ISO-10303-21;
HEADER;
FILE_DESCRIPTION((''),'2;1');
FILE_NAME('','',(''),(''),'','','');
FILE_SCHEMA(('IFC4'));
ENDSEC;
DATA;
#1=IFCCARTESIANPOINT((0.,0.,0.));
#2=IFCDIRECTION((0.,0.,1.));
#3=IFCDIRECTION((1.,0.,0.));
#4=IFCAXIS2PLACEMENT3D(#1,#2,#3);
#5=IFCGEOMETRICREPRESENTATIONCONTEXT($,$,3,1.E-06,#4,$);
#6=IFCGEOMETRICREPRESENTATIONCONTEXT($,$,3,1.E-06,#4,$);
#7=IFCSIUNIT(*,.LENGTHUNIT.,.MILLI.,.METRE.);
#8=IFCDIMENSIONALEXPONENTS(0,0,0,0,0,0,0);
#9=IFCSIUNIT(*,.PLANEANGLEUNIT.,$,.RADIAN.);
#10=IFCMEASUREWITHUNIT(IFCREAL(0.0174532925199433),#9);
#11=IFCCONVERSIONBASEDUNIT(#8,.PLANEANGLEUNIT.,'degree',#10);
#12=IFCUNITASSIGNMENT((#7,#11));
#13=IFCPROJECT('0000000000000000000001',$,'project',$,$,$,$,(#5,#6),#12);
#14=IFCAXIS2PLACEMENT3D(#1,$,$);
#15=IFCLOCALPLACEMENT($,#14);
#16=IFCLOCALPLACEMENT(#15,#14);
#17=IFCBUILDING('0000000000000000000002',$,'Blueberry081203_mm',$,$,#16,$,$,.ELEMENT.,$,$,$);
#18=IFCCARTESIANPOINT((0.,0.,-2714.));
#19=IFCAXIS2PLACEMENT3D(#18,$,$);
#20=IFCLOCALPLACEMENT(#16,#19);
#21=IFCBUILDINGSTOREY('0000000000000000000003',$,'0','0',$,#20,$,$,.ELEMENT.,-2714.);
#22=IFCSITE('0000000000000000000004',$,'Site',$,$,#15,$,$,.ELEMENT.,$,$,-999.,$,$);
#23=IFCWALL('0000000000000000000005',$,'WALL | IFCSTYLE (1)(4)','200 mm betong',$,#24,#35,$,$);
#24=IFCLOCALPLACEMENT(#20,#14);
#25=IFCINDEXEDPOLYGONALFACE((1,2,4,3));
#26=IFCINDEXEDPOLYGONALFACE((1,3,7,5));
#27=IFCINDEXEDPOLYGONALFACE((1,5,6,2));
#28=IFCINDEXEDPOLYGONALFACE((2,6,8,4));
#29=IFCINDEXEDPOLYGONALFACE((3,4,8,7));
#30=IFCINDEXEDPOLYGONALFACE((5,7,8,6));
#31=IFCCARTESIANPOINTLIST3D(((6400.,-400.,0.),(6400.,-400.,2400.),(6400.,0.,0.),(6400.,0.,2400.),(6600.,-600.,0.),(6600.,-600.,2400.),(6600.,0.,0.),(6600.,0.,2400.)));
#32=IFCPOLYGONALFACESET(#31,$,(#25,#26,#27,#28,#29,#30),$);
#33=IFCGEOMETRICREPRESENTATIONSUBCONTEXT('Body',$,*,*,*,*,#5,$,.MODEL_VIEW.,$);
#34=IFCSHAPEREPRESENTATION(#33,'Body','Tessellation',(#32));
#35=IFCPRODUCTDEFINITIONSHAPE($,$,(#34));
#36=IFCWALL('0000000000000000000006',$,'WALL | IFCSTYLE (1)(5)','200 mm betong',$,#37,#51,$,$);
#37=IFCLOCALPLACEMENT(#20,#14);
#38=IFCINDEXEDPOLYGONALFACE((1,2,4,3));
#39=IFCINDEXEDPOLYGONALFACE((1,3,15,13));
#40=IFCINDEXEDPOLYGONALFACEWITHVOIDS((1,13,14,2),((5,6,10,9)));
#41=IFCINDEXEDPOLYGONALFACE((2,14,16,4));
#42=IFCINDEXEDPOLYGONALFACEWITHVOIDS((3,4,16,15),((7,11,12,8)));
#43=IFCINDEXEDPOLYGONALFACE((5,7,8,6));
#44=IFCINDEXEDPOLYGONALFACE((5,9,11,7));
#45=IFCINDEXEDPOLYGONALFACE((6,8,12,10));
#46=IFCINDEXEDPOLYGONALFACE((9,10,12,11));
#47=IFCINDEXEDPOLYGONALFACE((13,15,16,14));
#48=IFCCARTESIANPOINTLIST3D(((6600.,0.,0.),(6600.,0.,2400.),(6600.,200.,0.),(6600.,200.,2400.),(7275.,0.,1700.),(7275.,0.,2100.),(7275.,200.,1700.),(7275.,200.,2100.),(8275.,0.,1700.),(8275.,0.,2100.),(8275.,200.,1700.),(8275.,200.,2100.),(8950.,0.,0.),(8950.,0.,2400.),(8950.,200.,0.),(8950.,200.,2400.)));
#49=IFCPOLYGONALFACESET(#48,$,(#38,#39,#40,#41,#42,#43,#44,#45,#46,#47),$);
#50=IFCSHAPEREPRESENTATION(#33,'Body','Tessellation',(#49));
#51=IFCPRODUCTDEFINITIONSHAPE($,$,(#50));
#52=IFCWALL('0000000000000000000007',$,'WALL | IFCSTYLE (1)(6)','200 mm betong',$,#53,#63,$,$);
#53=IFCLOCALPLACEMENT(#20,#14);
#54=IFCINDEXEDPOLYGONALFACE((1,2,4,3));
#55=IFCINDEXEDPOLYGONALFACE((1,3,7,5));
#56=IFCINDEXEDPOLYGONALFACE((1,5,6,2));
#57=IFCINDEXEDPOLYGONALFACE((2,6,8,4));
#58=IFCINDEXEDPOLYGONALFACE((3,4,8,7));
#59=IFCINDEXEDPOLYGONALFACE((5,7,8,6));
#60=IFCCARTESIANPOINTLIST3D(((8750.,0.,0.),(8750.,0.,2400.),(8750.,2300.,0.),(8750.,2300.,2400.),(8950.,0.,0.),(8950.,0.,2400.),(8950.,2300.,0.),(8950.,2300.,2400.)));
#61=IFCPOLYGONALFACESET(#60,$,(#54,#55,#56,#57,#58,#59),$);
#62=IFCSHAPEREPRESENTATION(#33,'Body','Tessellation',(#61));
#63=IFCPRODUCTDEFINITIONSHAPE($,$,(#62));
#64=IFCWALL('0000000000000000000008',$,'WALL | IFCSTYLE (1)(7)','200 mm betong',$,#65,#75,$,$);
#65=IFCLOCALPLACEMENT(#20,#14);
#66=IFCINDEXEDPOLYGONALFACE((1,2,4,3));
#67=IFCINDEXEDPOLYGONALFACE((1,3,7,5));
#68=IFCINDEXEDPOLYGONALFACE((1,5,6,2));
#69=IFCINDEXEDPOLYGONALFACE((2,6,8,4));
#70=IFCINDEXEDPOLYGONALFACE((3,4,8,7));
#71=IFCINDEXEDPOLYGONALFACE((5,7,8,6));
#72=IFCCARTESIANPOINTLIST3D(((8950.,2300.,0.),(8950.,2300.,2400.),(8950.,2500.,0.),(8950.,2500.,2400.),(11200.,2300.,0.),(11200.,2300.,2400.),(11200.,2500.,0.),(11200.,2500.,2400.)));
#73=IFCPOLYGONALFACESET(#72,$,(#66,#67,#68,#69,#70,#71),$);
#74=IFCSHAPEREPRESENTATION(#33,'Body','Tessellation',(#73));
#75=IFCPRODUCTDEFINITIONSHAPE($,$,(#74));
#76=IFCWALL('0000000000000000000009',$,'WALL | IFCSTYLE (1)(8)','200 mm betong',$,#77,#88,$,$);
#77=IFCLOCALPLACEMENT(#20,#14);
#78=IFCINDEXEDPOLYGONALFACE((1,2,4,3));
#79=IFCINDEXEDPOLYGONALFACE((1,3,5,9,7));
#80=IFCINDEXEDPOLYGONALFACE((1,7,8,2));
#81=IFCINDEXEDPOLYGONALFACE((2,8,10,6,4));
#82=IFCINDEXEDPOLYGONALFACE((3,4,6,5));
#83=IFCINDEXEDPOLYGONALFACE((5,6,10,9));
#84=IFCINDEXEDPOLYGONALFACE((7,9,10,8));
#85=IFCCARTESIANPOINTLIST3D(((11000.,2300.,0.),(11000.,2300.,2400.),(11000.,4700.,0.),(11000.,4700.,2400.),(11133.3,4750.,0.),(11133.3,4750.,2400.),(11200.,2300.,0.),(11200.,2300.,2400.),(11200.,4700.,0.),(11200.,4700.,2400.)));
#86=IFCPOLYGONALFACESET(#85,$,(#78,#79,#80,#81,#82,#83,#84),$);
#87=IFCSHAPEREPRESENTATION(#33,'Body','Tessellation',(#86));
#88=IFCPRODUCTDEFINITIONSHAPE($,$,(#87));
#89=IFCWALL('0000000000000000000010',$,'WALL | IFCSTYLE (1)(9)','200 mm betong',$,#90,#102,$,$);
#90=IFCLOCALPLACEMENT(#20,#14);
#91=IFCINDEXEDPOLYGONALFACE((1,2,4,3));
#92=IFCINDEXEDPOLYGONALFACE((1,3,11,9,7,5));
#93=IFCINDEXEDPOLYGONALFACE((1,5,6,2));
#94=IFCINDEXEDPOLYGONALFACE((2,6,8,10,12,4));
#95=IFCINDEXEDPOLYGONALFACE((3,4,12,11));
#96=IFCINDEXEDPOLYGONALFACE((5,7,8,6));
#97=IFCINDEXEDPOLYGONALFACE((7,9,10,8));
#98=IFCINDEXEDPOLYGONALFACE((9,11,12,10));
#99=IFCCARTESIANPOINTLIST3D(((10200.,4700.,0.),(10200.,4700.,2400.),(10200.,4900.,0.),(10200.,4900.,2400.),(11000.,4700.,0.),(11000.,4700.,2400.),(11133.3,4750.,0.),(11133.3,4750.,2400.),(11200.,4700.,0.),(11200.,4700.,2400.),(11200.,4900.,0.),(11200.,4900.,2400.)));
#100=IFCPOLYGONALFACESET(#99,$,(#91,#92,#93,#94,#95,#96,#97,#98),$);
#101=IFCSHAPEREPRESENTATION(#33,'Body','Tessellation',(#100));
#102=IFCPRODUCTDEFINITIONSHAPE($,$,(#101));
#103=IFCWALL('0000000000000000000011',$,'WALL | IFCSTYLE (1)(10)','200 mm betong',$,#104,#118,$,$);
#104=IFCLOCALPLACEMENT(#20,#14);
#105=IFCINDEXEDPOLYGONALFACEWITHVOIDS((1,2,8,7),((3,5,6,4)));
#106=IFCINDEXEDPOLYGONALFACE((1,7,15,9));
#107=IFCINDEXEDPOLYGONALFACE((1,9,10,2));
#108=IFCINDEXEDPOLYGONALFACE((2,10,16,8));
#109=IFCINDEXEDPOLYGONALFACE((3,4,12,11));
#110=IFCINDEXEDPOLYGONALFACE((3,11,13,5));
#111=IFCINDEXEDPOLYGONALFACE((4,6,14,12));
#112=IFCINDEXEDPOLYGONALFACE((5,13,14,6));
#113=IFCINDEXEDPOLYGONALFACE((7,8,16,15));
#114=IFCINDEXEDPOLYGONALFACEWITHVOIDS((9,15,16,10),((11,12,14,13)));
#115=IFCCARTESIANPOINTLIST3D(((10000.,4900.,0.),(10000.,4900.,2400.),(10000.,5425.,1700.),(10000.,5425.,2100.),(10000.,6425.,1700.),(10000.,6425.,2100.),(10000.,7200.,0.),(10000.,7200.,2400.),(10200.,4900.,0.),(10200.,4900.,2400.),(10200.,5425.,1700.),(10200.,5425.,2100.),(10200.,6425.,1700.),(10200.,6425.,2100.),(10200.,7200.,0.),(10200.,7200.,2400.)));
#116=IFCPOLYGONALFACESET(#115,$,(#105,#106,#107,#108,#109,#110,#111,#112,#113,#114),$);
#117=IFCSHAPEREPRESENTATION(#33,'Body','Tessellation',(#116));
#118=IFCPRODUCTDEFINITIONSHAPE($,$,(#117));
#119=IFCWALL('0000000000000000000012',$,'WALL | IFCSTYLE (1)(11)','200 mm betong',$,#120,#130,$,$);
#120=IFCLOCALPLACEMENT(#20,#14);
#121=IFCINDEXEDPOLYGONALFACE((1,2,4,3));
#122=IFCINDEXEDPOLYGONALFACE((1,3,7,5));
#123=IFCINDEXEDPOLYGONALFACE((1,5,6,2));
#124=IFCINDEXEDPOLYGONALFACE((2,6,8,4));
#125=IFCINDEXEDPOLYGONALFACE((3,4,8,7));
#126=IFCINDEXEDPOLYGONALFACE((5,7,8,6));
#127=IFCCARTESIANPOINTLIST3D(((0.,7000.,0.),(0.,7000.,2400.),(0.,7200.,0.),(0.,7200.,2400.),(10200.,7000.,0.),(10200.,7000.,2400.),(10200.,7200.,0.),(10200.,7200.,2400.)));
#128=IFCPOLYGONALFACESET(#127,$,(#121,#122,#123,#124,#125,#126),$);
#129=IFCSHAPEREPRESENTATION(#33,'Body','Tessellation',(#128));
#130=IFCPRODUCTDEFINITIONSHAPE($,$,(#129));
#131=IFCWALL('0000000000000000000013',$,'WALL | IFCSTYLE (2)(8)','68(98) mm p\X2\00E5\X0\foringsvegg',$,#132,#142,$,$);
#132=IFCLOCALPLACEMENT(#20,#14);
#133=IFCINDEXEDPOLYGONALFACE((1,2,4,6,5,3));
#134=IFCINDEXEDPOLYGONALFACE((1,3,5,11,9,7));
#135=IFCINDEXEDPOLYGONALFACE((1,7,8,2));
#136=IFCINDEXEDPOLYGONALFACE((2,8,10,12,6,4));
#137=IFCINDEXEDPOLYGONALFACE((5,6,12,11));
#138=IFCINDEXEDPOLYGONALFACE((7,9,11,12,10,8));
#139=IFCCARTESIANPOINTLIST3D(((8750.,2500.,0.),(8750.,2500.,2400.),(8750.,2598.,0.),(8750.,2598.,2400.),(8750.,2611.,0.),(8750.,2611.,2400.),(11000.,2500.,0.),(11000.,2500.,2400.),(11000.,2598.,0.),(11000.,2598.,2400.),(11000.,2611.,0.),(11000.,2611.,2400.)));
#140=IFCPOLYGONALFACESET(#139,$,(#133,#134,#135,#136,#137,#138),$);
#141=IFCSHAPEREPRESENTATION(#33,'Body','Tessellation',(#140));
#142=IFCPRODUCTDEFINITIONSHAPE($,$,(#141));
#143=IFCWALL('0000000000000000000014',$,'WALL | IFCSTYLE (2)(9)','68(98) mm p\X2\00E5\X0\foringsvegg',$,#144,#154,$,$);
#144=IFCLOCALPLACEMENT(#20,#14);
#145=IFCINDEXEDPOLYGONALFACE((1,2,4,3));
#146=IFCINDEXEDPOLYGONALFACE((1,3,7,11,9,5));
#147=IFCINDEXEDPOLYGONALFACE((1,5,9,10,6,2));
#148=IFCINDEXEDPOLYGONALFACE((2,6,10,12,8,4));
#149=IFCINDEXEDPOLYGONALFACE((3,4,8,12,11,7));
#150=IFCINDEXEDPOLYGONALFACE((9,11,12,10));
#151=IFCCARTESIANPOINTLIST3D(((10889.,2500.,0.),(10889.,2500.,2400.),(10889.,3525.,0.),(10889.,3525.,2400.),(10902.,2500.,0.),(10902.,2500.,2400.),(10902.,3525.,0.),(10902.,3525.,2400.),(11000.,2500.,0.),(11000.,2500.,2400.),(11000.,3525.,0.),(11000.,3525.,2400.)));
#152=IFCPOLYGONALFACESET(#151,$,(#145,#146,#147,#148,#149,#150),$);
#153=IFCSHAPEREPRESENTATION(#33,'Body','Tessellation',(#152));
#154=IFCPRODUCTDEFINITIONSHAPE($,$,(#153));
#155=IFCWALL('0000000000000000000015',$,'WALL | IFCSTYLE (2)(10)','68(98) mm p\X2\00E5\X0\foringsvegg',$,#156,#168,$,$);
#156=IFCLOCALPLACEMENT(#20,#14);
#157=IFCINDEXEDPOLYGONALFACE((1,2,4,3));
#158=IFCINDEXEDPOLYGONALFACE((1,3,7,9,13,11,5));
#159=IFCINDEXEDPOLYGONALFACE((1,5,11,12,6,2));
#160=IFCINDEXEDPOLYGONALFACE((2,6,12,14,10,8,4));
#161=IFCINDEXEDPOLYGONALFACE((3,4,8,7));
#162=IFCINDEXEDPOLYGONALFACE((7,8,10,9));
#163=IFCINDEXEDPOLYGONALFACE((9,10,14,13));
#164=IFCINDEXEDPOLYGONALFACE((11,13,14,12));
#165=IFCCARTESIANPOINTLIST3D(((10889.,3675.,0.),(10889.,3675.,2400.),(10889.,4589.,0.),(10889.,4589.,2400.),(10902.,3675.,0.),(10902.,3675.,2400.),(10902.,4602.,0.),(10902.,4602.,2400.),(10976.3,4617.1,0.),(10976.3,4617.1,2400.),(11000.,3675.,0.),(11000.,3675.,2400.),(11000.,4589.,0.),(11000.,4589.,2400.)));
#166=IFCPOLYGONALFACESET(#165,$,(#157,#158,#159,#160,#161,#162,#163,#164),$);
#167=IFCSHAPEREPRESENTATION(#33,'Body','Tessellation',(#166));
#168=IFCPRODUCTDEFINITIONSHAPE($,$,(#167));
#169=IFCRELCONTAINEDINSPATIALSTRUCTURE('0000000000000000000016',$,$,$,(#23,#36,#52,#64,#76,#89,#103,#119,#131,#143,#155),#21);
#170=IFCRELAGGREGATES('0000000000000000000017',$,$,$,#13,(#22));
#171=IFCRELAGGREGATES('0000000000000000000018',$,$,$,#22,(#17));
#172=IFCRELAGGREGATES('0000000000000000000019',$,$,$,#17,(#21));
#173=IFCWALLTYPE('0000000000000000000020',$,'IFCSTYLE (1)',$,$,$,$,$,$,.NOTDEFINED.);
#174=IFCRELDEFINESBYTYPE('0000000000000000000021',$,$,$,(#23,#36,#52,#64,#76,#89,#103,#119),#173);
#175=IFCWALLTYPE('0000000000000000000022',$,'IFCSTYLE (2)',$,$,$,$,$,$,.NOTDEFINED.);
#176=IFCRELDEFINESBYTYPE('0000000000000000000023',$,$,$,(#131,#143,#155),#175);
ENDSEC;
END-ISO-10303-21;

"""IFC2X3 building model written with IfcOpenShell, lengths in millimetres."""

from ifc_helpers import new_model, entity, si_unit, converted_unit, frame, frame_2d, origin, origin_with_axes, origin_2d_with_axis, place, context, subcontext, project, spatial, polyline, segment, composite_curve, rectangle, outline, extrude, type_object, element, save


model = new_model("IFC2X3")

# Units and contexts
context_of_model_1 = context(None, 3, precision=1e-06, world=origin_with_axes())
context_of_model_2 = context(None, 3, precision=1e-06, world=origin_with_axes())
body_context = subcontext(context_of_model_1, "Body", None, "MODEL_VIEW")
ifc_project = project(units=[si_unit("LENGTHUNIT", "METRE", prefix="MILLI"), converted_unit("PLANEANGLEUNIT", "degree", entity("IfcReal", 0.0174532925199433), si_unit("PLANEANGLEUNIT", "RADIAN"), dimensions=[0, 0, 0, 0, 0, 0, 0])], contexts=[context_of_model_1, context_of_model_2])

# Site, building, storey
site_placement = place(None, origin())
site = spatial("IfcSite", under=ifc_project, at=site_placement, Name="Site", CompositionType="ELEMENT", RefElevation=-999.0)
building_placement = place(site_placement, origin())
building = spatial("IfcBuilding", under=site, at=building_placement, Name="Blueberry081203_mm", CompositionType="ELEMENT")
storey_placement = place(building_placement, frame((0.0, 0.0, -2714.0)))
storey = spatial("IfcBuildingStorey", under=building, at=storey_placement, Name="0", Description="0", CompositionType="ELEMENT", Elevation=-2714.0)

# Wall
wall_type_1 = type_object("IfcWallType", Name="IFCSTYLE (1)", PredefinedType="NOTDEFINED")
wall_1_placement = place(storey_placement, frame((6600.0, -600.0, 0.0), z_axis=(0.0, 0.0, 1.0), x_axis=(0.0, 1.0, 0.0)))
element("IfcWall", 1, at=wall_1_placement, inside=storey, type_object=wall_type_1, Name="WALL | IFCSTYLE (1)(4)", Description="200 mm betong", context=body_context, shape_type="SweptSolid", held_by="IfcProductRepresentation", body=[
    extrude(outline(composite_curve([segment(polyline([(200.0, 200.0), (0.0, 0.0)]), True, "CONTINUOUS"), segment(polyline([(0.0, 0.0), (600.0, 0.0)]), True, "CONTINUOUS"), segment(polyline([(600.0, 0.0), (600.0, 200.0)]), True, "CONTINUOUS"), segment(polyline([(600.0, 200.0), (200.0, 200.0)]), True, "CONTINUOUS")], self_intersect=False)), origin(), (0.0, 0.0, 1.0), 2400.0),
])

# Wall, opening
wall_2_placement = place(storey_placement, frame((6600.0, 0.0, 0.0)))
wall_2 = element("IfcWall", 2, at=wall_2_placement, inside=storey, type_object=wall_type_1, Name="WALL | IFCSTYLE (1)(5)", Description="200 mm betong", context=body_context, shape_type="SweptSolid", held_by="IfcProductRepresentation", body=[
    extrude(rectangle(XDim=200.0, YDim=2350.0, at=frame_2d((1175.0, 100.0), x_axis=(0.0, -1.0))), origin(), (0.0, 0.0, 1.0), 2400.0),
])
opening_1_placement = place(wall_2_placement, frame((675.0, 100.0, 1700.0)))
element("IfcOpeningElement", 3, at=opening_1_placement, cuts=wall_2, context=body_context, shape_type="SweptSolid", held_by="IfcProductRepresentation", body=[
    extrude(rectangle(XDim=1000.0, YDim=400.0, at=origin_2d_with_axis()), frame((500.0, 100.0, 200.0), z_axis=(0.0, -1.0, 0.0), x_axis=(1.0, 0.0, 0.0)), (0.0, 0.0, 1.0), 200.0),
])

# Walls
wall_3_placement = place(storey_placement, frame((8950.0, 0.0, 0.0), z_axis=(0.0, 0.0, 1.0), x_axis=(0.0, 1.0, 0.0)))
element("IfcWall", 4, at=wall_3_placement, inside=storey, type_object=wall_type_1, Name="WALL | IFCSTYLE (1)(6)", Description="200 mm betong", context=body_context, shape_type="SweptSolid", held_by="IfcProductRepresentation", body=[
    extrude(rectangle(XDim=200.0, YDim=2300.0, at=frame_2d((1150.0, 100.0), x_axis=(0.0, -1.0))), origin(), (0.0, 0.0, 1.0), 2400.0),
])
wall_4_placement = place(storey_placement, frame((8950.0, 2300.0, 0.0)))
element("IfcWall", 5, at=wall_4_placement, inside=storey, type_object=wall_type_1, Name="WALL | IFCSTYLE (1)(7)", Description="200 mm betong", context=body_context, shape_type="SweptSolid", held_by="IfcProductRepresentation", body=[
    extrude(rectangle(XDim=200.0, YDim=2250.0, at=frame_2d((1125.0, 100.0), x_axis=(0.0, -1.0))), origin(), (0.0, 0.0, 1.0), 2400.0),
])
wall_5_placement = place(storey_placement, frame((11200.0, 2300.0, 0.0), z_axis=(0.0, 0.0, 1.0), x_axis=(0.0, 1.0, 0.0)))
element("IfcWall", 6, at=wall_5_placement, inside=storey, type_object=wall_type_1, Name="WALL | IFCSTYLE (1)(8)", Description="200 mm betong", context=body_context, shape_type="SweptSolid", held_by="IfcProductRepresentation", body=[
    extrude(outline(composite_curve([segment(polyline([(0.0, 200.0), (0.0, 0.0)]), True, "CONTINUOUS"), segment(polyline([(0.0, 0.0), (2400.0, 0.0)]), True, "CONTINUOUS"), segment(polyline([(2400.0, 0.0), (2450.0, 66.7)]), True, "CONTINUOUS"), segment(polyline([(2450.0, 66.7), (2400.0, 200.0)]), True, "CONTINUOUS"), segment(polyline([(2400.0, 200.0), (0.0, 200.0)]), True, "CONTINUOUS")], self_intersect=False)), origin(), (0.0, 0.0, 1.0), 2400.0),
])
wall_6_placement = place(storey_placement, frame((11200.0, 4900.0, 0.0), z_axis=(0.0, 0.0, 1.0), x_axis=(-1.0, 0.0, 0.0)))
element("IfcWall", 7, at=wall_6_placement, inside=storey, type_object=wall_type_1, Name="WALL | IFCSTYLE (1)(9)", Description="200 mm betong", context=body_context, shape_type="SweptSolid", held_by="IfcProductRepresentation", body=[
    extrude(outline(composite_curve([segment(polyline([(0.0, 200.0), (0.0, 0.0)]), True, "CONTINUOUS"), segment(polyline([(0.0, 0.0), (0.0, 0.0)]), True, "CONTINUOUS"), segment(polyline([(0.0, 0.0), (1000.0, 0.0)]), True, "CONTINUOUS"), segment(polyline([(1000.0, 0.0), (1000.0, 200.0)]), True, "CONTINUOUS"), segment(polyline([(1000.0, 200.0), (200.0, 200.0)]), True, "CONTINUOUS"), segment(polyline([(200.0, 200.0), (66.7, 150.0)]), True, "CONTINUOUS"), segment(polyline([(66.7, 150.0), (0.0, 200.0)]), True, "CONTINUOUS"), segment(polyline([(0.0, 200.0), (0.0, 200.0)]), True, "CONTINUOUS")], self_intersect=False)), origin(), (0.0, 0.0, 1.0), 2400.0),
])

# Wall, opening
wall_7_placement = place(storey_placement, frame((10200.0, 4900.0, 0.0), z_axis=(0.0, 0.0, 1.0), x_axis=(0.0, 1.0, 0.0)))
wall_7 = element("IfcWall", 8, at=wall_7_placement, inside=storey, type_object=wall_type_1, Name="WALL | IFCSTYLE (1)(10)", Description="200 mm betong", context=body_context, shape_type="SweptSolid", held_by="IfcProductRepresentation", body=[
    extrude(rectangle(XDim=200.0, YDim=2300.0, at=frame_2d((1150.0, 100.0), x_axis=(0.0, -1.0))), origin(), (0.0, 0.0, 1.0), 2400.0),
])
opening_2_placement = place(wall_7_placement, frame((525.0, 100.0, 1700.0)))
element("IfcOpeningElement", 9, at=opening_2_placement, cuts=wall_7, context=body_context, shape_type="SweptSolid", held_by="IfcProductRepresentation", body=[
    extrude(rectangle(XDim=1000.0, YDim=400.0, at=origin_2d_with_axis()), frame((500.0, 100.0, 200.0), z_axis=(0.0, -1.0, 0.0), x_axis=(1.0, 0.0, 0.0)), (0.0, 0.0, 1.0), 200.0),
])

# Walls
wall_8_placement = place(storey_placement, frame((10200.0, 7200.0, 0.0), z_axis=(0.0, 0.0, 1.0), x_axis=(-1.0, 0.0, 0.0)))
element("IfcWall", 10, at=wall_8_placement, inside=storey, type_object=wall_type_1, Name="WALL | IFCSTYLE (1)(11)", Description="200 mm betong", context=body_context, shape_type="SweptSolid", held_by="IfcProductRepresentation", body=[
    extrude(rectangle(XDim=200.0, YDim=10200.0, at=frame_2d((5100.0, 100.0), x_axis=(0.0, -1.0))), origin(), (0.0, 0.0, 1.0), 2400.0),
])
wall_type_2 = type_object("IfcWallType", Name="IFCSTYLE (2)", PredefinedType="NOTDEFINED")
wall_9_placement = place(storey_placement, frame((8750.0, 2500.0, 0.0)))
element("IfcWall", 11, at=wall_9_placement, inside=storey, type_object=wall_type_2, Name="WALL | IFCSTYLE (2)(8)", Description="68(98) mm påforingsvegg", context=body_context, shape_type="SweptSolid", held_by="IfcProductRepresentation", body=[
    extrude(outline(composite_curve([segment(polyline([(0.0, 98.0), (0.0, 0.0)]), True, "CONTINUOUS"), segment(polyline([(0.0, 0.0), (2250.0, 0.0)]), True, "CONTINUOUS"), segment(polyline([(2250.0, 0.0), (2250.0, 98.0)]), True, "CONTINUOUS"), segment(polyline([(2250.0, 98.0), (2250.0, 111.0)]), True, "CONTINUOUS"), segment(polyline([(2250.0, 111.0), (0.0, 111.0)]), True, "CONTINUOUS"), segment(polyline([(0.0, 111.0), (0.0, 98.0)]), True, "CONTINUOUS")], self_intersect=False)), origin(), (0.0, 0.0, 1.0), 2400.0),
])
wall_10_placement = place(storey_placement, frame((11000.0, 2500.0, 0.0), z_axis=(0.0, 0.0, 1.0), x_axis=(0.0, 1.0, 0.0)))
element("IfcWall", 12, at=wall_10_placement, inside=storey, type_object=wall_type_2, Name="WALL | IFCSTYLE (2)(9)", Description="68(98) mm påforingsvegg", context=body_context, shape_type="SweptSolid", held_by="IfcProductRepresentation", body=[
    extrude(outline(composite_curve([segment(polyline([(0.0, 98.0), (0.0, 0.0)]), True, "CONTINUOUS"), segment(polyline([(0.0, 0.0), (1025.0, 0.0)]), True, "CONTINUOUS"), segment(polyline([(1025.0, 0.0), (1025.0, 98.0)]), True, "CONTINUOUS"), segment(polyline([(1025.0, 98.0), (1025.0, 111.0)]), True, "CONTINUOUS"), segment(polyline([(1025.0, 111.0), (0.0, 111.0)]), True, "CONTINUOUS"), segment(polyline([(0.0, 111.0), (0.0, 98.0)]), True, "CONTINUOUS")], self_intersect=False)), origin(), (0.0, 0.0, 1.0), 2400.0),
])
wall_11_placement = place(storey_placement, frame((11000.0, 3675.0, 0.0), z_axis=(0.0, 0.0, 1.0), x_axis=(0.0, 1.0, 0.0)))
element("IfcWall", 13, at=wall_11_placement, inside=storey, type_object=wall_type_2, Name="WALL | IFCSTYLE (2)(10)", Description="68(98) mm påforingsvegg", context=body_context, shape_type="SweptSolid", held_by="IfcProductRepresentation", body=[
    extrude(outline(composite_curve([segment(polyline([(0.0, 98.0), (0.0, 0.0)]), True, "CONTINUOUS"), segment(polyline([(0.0, 0.0), (914.0, 0.0)]), True, "CONTINUOUS"), segment(polyline([(914.0, 0.0), (942.1, 23.7)]), True, "CONTINUOUS"), segment(polyline([(942.1, 23.7), (927.0, 98.0)]), True, "CONTINUOUS"), segment(polyline([(927.0, 98.0), (914.0, 111.0)]), True, "CONTINUOUS"), segment(polyline([(914.0, 111.0), (0.0, 111.0)]), True, "CONTINUOUS"), segment(polyline([(0.0, 111.0), (0.0, 98.0)]), True, "CONTINUOUS")], self_intersect=False)), origin(), (0.0, 0.0, 1.0), 2400.0),
])

save(model, "model.ifc")
